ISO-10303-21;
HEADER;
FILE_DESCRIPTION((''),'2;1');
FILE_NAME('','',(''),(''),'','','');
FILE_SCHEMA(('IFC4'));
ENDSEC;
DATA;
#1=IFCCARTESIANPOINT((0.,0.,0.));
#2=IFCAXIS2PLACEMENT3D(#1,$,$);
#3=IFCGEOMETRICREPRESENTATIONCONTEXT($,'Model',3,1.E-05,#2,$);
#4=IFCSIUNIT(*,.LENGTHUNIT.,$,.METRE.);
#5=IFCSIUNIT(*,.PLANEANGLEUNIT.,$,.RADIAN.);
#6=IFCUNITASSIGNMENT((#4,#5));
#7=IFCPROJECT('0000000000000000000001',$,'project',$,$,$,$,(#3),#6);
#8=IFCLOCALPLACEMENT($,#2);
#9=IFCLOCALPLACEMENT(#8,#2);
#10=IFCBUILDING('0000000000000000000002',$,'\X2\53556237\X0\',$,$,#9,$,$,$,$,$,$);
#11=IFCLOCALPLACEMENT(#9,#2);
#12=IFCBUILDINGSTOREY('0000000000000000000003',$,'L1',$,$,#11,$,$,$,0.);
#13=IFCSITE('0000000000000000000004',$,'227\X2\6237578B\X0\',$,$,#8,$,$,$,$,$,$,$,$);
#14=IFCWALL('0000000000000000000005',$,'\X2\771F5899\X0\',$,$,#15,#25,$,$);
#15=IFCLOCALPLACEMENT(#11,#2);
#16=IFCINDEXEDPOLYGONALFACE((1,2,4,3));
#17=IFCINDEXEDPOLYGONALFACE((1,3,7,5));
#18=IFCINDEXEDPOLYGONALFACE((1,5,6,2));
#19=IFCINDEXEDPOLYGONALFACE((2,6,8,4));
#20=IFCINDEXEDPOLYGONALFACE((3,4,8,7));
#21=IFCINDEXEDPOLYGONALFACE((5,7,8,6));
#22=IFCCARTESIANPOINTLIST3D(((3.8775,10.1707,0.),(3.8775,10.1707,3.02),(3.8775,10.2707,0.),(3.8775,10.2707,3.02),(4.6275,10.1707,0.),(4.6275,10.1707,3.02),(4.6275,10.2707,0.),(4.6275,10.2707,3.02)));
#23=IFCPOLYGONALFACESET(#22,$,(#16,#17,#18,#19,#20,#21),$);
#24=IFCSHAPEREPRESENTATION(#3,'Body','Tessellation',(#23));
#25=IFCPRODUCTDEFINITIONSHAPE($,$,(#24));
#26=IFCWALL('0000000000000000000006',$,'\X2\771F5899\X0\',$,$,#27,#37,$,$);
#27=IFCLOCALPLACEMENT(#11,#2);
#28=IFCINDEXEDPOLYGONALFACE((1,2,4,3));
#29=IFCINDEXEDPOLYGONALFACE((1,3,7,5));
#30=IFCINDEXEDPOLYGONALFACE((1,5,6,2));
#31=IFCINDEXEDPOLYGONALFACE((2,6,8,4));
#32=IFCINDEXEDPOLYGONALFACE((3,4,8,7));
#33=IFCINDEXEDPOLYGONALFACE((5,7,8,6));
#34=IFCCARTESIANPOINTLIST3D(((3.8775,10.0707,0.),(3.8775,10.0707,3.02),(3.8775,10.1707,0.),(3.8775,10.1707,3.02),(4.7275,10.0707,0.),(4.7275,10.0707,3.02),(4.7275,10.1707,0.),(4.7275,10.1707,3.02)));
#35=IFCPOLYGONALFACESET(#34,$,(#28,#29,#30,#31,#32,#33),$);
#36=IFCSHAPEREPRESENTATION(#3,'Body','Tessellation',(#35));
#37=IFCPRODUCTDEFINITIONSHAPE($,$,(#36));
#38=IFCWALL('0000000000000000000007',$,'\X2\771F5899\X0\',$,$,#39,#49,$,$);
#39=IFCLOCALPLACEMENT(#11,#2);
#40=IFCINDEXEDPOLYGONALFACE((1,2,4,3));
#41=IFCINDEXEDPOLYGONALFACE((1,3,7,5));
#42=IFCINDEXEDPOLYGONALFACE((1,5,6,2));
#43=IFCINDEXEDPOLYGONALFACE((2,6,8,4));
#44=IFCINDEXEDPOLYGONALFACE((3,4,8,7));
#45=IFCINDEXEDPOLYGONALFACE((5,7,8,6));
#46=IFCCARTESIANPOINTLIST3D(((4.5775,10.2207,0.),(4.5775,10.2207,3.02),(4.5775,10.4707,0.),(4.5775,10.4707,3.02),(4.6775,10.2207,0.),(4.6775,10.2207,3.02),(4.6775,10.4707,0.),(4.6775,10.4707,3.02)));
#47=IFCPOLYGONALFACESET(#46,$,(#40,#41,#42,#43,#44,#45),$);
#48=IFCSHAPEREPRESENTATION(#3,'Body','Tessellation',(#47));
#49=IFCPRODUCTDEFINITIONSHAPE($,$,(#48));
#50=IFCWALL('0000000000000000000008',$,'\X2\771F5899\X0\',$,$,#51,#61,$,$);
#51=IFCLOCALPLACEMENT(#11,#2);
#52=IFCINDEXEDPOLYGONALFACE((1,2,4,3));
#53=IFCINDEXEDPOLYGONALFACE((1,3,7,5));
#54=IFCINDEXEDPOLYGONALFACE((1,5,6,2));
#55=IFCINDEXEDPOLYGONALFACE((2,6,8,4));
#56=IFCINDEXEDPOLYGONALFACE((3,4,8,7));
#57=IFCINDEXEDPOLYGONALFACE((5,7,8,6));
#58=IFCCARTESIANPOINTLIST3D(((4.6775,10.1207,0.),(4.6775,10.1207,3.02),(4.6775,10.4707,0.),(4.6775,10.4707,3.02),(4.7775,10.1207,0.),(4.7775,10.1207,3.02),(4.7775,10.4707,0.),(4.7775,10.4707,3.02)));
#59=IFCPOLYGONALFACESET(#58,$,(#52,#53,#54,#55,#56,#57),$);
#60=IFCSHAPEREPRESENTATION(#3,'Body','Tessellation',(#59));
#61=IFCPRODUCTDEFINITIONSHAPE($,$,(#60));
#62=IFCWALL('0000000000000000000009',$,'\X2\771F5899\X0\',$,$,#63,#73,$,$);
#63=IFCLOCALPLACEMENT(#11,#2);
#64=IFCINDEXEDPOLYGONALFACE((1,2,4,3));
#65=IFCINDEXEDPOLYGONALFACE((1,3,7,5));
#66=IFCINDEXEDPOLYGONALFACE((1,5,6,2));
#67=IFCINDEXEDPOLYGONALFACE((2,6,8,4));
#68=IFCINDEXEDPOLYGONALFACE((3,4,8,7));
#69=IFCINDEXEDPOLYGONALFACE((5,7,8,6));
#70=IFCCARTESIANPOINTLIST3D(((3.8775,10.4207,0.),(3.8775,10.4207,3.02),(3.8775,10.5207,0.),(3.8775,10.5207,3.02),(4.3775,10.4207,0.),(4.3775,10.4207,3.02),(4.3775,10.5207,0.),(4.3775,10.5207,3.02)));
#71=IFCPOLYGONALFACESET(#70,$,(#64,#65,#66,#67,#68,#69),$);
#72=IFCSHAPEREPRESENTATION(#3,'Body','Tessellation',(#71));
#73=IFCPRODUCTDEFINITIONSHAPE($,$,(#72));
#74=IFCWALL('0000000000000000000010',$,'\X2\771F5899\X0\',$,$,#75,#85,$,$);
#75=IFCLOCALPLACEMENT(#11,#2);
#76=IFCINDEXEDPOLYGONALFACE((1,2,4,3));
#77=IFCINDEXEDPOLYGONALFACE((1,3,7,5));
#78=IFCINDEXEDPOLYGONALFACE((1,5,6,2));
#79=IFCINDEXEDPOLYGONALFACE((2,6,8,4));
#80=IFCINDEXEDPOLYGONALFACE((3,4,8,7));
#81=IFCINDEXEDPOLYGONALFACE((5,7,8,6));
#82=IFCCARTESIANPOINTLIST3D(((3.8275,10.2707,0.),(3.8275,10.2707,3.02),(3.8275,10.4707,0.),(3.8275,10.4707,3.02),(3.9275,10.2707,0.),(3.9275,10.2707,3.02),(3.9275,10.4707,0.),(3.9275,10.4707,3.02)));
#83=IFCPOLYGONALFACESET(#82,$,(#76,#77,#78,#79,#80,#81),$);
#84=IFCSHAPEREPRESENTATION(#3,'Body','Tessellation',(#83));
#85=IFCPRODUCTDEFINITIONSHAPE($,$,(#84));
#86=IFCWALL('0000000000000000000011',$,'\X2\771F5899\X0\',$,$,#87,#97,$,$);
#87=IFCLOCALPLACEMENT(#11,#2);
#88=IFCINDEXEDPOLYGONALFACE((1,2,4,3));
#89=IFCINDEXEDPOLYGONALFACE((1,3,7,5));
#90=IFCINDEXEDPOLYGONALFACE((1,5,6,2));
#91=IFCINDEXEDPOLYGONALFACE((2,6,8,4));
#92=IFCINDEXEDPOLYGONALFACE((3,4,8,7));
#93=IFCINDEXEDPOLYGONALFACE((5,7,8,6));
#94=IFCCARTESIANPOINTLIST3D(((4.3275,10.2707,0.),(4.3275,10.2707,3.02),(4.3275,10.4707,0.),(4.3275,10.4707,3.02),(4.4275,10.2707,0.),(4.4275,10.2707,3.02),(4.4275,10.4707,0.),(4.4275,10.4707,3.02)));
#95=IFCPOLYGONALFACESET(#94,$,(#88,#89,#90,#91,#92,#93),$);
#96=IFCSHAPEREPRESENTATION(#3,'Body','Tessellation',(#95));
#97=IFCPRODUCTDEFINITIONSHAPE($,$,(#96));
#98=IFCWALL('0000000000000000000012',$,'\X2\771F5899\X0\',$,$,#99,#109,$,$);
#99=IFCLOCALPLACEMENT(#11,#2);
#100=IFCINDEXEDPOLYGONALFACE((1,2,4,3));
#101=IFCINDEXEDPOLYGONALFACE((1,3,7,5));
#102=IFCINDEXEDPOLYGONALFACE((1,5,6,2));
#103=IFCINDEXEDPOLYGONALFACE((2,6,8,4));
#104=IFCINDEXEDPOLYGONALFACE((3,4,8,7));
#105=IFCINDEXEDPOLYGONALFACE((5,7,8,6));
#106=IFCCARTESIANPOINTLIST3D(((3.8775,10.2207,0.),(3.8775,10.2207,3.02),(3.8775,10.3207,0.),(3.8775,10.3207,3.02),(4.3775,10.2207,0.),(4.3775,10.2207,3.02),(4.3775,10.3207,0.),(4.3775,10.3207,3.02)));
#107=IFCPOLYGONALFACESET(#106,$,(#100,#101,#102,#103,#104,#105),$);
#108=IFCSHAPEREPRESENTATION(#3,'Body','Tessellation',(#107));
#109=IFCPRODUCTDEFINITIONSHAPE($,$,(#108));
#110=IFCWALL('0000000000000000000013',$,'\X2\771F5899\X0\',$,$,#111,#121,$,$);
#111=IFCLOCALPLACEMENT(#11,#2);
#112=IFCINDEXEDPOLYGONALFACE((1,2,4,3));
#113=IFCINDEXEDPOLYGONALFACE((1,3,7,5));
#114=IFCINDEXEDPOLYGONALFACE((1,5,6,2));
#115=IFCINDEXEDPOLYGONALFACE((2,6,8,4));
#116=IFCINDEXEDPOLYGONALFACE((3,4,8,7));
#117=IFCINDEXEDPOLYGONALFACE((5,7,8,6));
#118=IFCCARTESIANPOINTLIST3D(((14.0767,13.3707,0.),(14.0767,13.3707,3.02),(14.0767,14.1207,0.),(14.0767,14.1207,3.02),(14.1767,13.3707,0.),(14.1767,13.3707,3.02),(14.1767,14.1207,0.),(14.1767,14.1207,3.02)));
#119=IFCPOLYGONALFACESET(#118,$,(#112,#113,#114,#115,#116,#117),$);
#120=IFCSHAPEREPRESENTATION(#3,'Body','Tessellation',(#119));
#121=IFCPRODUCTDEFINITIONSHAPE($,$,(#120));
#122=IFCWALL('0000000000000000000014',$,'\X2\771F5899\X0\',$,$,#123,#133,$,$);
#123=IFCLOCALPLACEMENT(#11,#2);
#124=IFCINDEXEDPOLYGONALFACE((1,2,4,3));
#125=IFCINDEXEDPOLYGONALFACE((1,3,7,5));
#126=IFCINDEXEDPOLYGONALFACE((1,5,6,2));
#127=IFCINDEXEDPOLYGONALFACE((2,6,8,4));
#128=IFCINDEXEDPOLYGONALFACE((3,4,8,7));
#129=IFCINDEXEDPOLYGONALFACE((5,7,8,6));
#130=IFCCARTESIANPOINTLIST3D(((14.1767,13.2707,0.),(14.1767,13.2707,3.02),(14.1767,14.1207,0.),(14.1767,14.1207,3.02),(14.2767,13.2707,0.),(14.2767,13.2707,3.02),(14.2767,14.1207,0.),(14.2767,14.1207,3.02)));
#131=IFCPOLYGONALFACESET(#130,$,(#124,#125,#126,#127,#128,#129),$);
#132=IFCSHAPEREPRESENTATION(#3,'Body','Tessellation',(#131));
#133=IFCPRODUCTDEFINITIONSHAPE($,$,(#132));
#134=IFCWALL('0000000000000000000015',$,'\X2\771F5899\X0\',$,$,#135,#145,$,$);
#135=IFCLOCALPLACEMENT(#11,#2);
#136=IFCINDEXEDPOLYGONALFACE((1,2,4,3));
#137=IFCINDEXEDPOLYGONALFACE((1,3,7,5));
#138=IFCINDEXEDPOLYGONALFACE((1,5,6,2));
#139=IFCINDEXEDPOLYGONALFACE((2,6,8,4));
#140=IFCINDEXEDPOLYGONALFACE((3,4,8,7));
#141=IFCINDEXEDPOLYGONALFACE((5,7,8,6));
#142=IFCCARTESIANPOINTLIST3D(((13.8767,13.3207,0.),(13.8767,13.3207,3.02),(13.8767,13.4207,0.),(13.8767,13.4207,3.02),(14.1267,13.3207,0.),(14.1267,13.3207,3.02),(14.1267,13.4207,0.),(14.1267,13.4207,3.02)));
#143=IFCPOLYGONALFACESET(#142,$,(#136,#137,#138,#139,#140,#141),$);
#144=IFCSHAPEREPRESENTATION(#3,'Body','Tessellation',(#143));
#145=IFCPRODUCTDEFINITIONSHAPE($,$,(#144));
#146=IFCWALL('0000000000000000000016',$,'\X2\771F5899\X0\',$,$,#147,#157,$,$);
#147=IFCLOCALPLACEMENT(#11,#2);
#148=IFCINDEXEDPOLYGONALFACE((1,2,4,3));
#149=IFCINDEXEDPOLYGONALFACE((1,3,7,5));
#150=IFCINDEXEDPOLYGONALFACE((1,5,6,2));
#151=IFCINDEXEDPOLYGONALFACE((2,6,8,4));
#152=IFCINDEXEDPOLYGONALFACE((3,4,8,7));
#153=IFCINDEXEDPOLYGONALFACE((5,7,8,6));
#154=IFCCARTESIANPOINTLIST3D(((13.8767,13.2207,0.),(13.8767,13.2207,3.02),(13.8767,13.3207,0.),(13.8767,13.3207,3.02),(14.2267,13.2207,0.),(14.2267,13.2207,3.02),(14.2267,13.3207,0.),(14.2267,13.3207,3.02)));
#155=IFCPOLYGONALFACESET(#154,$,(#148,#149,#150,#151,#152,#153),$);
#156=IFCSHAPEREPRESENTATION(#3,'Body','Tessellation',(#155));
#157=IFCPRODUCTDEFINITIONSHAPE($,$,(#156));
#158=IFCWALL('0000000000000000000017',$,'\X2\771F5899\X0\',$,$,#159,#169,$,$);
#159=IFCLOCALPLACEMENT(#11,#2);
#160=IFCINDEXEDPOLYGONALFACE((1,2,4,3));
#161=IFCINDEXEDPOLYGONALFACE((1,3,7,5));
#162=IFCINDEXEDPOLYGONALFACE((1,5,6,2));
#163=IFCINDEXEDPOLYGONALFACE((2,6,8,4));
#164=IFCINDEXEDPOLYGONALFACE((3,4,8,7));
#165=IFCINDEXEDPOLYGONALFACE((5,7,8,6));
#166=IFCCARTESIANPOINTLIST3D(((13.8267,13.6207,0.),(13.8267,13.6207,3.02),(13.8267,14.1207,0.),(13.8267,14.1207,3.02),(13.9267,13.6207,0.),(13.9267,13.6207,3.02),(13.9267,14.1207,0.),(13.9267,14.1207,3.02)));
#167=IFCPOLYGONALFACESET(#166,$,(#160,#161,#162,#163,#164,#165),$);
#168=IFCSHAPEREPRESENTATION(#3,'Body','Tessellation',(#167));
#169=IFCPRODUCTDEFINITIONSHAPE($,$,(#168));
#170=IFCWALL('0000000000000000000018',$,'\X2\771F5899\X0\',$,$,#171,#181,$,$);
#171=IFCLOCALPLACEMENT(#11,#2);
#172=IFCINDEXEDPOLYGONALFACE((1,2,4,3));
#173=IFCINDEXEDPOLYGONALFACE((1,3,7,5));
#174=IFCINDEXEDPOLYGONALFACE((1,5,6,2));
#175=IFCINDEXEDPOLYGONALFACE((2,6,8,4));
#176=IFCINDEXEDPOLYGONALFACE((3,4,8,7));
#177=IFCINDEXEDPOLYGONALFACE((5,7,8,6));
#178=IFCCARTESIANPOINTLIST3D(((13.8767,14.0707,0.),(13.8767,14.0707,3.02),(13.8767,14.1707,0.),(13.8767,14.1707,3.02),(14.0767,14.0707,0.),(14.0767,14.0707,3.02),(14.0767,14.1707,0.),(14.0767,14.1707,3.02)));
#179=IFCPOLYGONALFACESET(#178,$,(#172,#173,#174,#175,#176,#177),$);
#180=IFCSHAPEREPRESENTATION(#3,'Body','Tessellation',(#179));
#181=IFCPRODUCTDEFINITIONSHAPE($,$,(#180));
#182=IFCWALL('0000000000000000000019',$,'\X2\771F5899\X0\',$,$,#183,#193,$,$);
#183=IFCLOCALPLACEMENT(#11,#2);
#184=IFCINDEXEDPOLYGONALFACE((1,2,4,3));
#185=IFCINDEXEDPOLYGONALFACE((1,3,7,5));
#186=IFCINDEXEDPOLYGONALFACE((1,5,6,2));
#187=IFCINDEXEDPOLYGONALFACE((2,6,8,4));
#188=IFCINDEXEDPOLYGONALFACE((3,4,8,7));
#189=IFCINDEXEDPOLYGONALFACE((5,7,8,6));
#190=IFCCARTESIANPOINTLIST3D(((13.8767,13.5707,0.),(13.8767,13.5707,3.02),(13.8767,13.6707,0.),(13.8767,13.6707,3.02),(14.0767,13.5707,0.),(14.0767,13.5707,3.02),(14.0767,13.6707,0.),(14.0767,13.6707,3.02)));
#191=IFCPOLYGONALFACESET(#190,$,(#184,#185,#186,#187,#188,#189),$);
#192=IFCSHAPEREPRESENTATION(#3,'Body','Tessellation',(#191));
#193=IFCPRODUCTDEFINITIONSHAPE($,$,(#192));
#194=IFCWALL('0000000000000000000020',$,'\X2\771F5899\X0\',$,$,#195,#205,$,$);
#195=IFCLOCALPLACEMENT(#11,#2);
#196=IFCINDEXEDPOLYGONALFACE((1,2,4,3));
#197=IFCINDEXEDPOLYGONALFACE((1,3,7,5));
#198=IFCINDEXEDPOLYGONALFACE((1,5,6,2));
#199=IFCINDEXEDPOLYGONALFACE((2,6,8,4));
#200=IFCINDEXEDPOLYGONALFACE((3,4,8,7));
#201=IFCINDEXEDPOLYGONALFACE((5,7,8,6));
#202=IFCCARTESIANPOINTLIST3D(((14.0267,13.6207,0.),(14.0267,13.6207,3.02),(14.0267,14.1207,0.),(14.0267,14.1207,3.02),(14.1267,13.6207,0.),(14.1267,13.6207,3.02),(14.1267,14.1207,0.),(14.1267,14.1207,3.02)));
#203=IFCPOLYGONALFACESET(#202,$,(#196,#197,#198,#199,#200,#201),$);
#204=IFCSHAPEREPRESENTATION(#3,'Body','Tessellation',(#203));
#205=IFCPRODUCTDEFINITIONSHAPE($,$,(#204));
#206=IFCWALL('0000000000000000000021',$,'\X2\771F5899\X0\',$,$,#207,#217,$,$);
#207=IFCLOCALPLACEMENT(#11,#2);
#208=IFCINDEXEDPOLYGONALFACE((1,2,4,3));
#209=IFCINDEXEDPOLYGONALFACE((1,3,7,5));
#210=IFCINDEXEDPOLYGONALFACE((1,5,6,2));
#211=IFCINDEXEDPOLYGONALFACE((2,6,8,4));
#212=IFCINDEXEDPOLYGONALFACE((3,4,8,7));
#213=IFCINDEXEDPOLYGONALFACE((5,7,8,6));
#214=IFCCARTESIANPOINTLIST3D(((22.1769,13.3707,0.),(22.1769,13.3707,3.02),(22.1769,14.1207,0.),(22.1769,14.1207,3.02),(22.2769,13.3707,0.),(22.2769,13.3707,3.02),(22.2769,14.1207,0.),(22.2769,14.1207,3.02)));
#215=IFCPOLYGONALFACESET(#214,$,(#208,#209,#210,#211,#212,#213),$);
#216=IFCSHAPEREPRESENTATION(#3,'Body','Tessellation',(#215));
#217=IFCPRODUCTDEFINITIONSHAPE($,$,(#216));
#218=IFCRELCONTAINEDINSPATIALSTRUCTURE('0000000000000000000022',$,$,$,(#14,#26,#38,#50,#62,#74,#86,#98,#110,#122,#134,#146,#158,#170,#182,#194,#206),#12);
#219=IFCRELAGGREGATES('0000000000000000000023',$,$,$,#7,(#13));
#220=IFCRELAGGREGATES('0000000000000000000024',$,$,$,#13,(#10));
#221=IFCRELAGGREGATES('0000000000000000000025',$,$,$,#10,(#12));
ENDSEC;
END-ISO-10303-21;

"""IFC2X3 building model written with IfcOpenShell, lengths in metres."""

from ifc_helpers import new_model, si_unit, origin, place, context, project, spatial, polyline, outline, extrude, element, save


model = new_model("IFC2X3")

# Units and contexts
model_context = context("Model", 3, precision=1e-05, world=origin())
ifc_project = project(units=[si_unit("LENGTHUNIT", "METRE"), si_unit("PLANEANGLEUNIT", "RADIAN")], contexts=[model_context])

# Site, building, storey
site_placement = place(None, origin())
site = spatial("IfcSite", under=ifc_project, at=site_placement, Name="227户型")
building_placement = place(site_placement, origin())
building = spatial("IfcBuilding", under=site, at=building_placement, Name="单户")
storey_placement = place(building_placement, origin())
storey = spatial("IfcBuildingStorey", under=building, at=storey_placement, Name="L1", Elevation=0.0)

# Walls
wall_1_placement = place(storey_placement, origin())
element("IfcWall", 1, at=wall_1_placement, inside=storey, Name="真墙", context=model_context, shape_type="SweptSolid", body=[
    extrude(outline(polyline([(4.6275, 10.1707), (3.8775, 10.1707), (3.8775, 10.2707), (4.6275, 10.2707), (4.6275, 10.1707)])), origin(), (0.0, 0.0, 1.0), 3.02),
])
wall_2_placement = place(storey_placement, origin())
element("IfcWall", 2, at=wall_2_placement, inside=storey, Name="真墙", context=model_context, shape_type="SweptSolid", body=[
    extrude(outline(polyline([(3.8775, 10.1707), (4.7275, 10.1707), (4.7275, 10.0707), (3.8775, 10.0707), (3.8775, 10.1707)])), origin(), (0.0, 0.0, 1.0), 3.02),
])
wall_3_placement = place(storey_placement, origin())
element("IfcWall", 3, at=wall_3_placement, inside=storey, Name="真墙", context=model_context, shape_type="SweptSolid", body=[
    extrude(outline(polyline([(4.5775, 10.2207), (4.5775, 10.4707), (4.6775, 10.4707), (4.6775, 10.2207), (4.5775, 10.2207)])), origin(), (0.0, 0.0, 1.0), 3.02),
])
wall_4_placement = place(storey_placement, origin())
element("IfcWall", 4, at=wall_4_placement, inside=storey, Name="真墙", context=model_context, shape_type="SweptSolid", body=[
    extrude(outline(polyline([(4.6775, 10.1207), (4.6775, 10.4707), (4.7775, 10.4707), (4.7775, 10.1207), (4.6775, 10.1207)])), origin(), (0.0, 0.0, 1.0), 3.02),
])
wall_5_placement = place(storey_placement, origin())
element("IfcWall", 5, at=wall_5_placement, inside=storey, Name="真墙", context=model_context, shape_type="SweptSolid", body=[
    extrude(outline(polyline([(4.3775, 10.4207), (3.8775, 10.4207), (3.8775, 10.5207), (4.3775, 10.5207), (4.3775, 10.4207)])), origin(), (0.0, 0.0, 1.0), 3.02),
])
wall_6_placement = place(storey_placement, origin())
element("IfcWall", 6, at=wall_6_placement, inside=storey, Name="真墙", context=model_context, shape_type="SweptSolid", body=[
    extrude(outline(polyline([(3.9275, 10.4707), (3.9275, 10.2707), (3.8275, 10.2707), (3.8275, 10.4707), (3.9275, 10.4707)])), origin(), (0.0, 0.0, 1.0), 3.02),
])
wall_7_placement = place(storey_placement, origin())
element("IfcWall", 7, at=wall_7_placement, inside=storey, Name="真墙", context=model_context, shape_type="SweptSolid", body=[
    extrude(outline(polyline([(4.4275, 10.4707), (4.4275, 10.2707), (4.3275, 10.2707), (4.3275, 10.4707), (4.4275, 10.4707)])), origin(), (0.0, 0.0, 1.0), 3.02),
])
wall_8_placement = place(storey_placement, origin())
element("IfcWall", 8, at=wall_8_placement, inside=storey, Name="真墙", context=model_context, shape_type="SweptSolid", body=[
    extrude(outline(polyline([(4.3775, 10.2207), (3.8775, 10.2207), (3.8775, 10.3207), (4.3775, 10.3207), (4.3775, 10.2207)])), origin(), (0.0, 0.0, 1.0), 3.02),
])
wall_9_placement = place(storey_placement, origin())
element("IfcWall", 9, at=wall_9_placement, inside=storey, Name="真墙", context=model_context, shape_type="SweptSolid", body=[
    extrude(outline(polyline([(14.0767, 13.3707), (14.0767, 14.1207), (14.1767, 14.1207), (14.1767, 13.3707), (14.0767, 13.3707)])), origin(), (0.0, 0.0, 1.0), 3.02),
])
wall_10_placement = place(storey_placement, origin())
element("IfcWall", 10, at=wall_10_placement, inside=storey, Name="真墙", context=model_context, shape_type="SweptSolid", body=[
    extrude(outline(polyline([(14.2767, 14.1207), (14.2767, 13.2707), (14.1767, 13.2707), (14.1767, 14.1207), (14.2767, 14.1207)])), origin(), (0.0, 0.0, 1.0), 3.02),
])
wall_11_placement = place(storey_placement, origin())
element("IfcWall", 11, at=wall_11_placement, inside=storey, Name="真墙", context=model_context, shape_type="SweptSolid", body=[
    extrude(outline(polyline([(14.1267, 13.3207), (13.8767, 13.3207), (13.8767, 13.4207), (14.1267, 13.4207), (14.1267, 13.3207)])), origin(), (0.0, 0.0, 1.0), 3.02),
])
wall_12_placement = place(storey_placement, origin())
element("IfcWall", 12, at=wall_12_placement, inside=storey, Name="真墙", context=model_context, shape_type="SweptSolid", body=[
    extrude(outline(polyline([(14.2267, 13.2207), (13.8767, 13.2207), (13.8767, 13.3207), (14.2267, 13.3207), (14.2267, 13.2207)])), origin(), (0.0, 0.0, 1.0), 3.02),
])
wall_13_placement = place(storey_placement, origin())
element("IfcWall", 13, at=wall_13_placement, inside=storey, Name="真墙", context=model_context, shape_type="SweptSolid", body=[
    extrude(outline(polyline([(13.8267, 13.6207), (13.8267, 14.1207), (13.9267, 14.1207), (13.9267, 13.6207), (13.8267, 13.6207)])), origin(), (0.0, 0.0, 1.0), 3.02),
])
wall_14_placement = place(storey_placement, origin())
element("IfcWall", 14, at=wall_14_placement, inside=storey, Name="真墙", context=model_context, shape_type="SweptSolid", body=[
    extrude(outline(polyline([(13.8767, 14.1707), (14.0767, 14.1707), (14.0767, 14.0707), (13.8767, 14.0707), (13.8767, 14.1707)])), origin(), (0.0, 0.0, 1.0), 3.02),
])
wall_15_placement = place(storey_placement, origin())
element("IfcWall", 15, at=wall_15_placement, inside=storey, Name="真墙", context=model_context, shape_type="SweptSolid", body=[
    extrude(outline(polyline([(13.8767, 13.6707), (14.0767, 13.6707), (14.0767, 13.5707), (13.8767, 13.5707), (13.8767, 13.6707)])), origin(), (0.0, 0.0, 1.0), 3.02),
])
wall_16_placement = place(storey_placement, origin())
element("IfcWall", 16, at=wall_16_placement, inside=storey, Name="真墙", context=model_context, shape_type="SweptSolid", body=[
    extrude(outline(polyline([(14.0267, 13.6207), (14.0267, 14.1207), (14.1267, 14.1207), (14.1267, 13.6207), (14.0267, 13.6207)])), origin(), (0.0, 0.0, 1.0), 3.02),
])
wall_17_placement = place(storey_placement, origin())
element("IfcWall", 17, at=wall_17_placement, inside=storey, Name="真墙", context=model_context, shape_type="SweptSolid", body=[
    extrude(outline(polyline([(22.1769, 13.3707), (22.1769, 14.1207), (22.2769, 14.1207), (22.2769, 13.3707), (22.1769, 13.3707)])), origin(), (0.0, 0.0, 1.0), 3.02),
])

save(model, "model.ifc")
